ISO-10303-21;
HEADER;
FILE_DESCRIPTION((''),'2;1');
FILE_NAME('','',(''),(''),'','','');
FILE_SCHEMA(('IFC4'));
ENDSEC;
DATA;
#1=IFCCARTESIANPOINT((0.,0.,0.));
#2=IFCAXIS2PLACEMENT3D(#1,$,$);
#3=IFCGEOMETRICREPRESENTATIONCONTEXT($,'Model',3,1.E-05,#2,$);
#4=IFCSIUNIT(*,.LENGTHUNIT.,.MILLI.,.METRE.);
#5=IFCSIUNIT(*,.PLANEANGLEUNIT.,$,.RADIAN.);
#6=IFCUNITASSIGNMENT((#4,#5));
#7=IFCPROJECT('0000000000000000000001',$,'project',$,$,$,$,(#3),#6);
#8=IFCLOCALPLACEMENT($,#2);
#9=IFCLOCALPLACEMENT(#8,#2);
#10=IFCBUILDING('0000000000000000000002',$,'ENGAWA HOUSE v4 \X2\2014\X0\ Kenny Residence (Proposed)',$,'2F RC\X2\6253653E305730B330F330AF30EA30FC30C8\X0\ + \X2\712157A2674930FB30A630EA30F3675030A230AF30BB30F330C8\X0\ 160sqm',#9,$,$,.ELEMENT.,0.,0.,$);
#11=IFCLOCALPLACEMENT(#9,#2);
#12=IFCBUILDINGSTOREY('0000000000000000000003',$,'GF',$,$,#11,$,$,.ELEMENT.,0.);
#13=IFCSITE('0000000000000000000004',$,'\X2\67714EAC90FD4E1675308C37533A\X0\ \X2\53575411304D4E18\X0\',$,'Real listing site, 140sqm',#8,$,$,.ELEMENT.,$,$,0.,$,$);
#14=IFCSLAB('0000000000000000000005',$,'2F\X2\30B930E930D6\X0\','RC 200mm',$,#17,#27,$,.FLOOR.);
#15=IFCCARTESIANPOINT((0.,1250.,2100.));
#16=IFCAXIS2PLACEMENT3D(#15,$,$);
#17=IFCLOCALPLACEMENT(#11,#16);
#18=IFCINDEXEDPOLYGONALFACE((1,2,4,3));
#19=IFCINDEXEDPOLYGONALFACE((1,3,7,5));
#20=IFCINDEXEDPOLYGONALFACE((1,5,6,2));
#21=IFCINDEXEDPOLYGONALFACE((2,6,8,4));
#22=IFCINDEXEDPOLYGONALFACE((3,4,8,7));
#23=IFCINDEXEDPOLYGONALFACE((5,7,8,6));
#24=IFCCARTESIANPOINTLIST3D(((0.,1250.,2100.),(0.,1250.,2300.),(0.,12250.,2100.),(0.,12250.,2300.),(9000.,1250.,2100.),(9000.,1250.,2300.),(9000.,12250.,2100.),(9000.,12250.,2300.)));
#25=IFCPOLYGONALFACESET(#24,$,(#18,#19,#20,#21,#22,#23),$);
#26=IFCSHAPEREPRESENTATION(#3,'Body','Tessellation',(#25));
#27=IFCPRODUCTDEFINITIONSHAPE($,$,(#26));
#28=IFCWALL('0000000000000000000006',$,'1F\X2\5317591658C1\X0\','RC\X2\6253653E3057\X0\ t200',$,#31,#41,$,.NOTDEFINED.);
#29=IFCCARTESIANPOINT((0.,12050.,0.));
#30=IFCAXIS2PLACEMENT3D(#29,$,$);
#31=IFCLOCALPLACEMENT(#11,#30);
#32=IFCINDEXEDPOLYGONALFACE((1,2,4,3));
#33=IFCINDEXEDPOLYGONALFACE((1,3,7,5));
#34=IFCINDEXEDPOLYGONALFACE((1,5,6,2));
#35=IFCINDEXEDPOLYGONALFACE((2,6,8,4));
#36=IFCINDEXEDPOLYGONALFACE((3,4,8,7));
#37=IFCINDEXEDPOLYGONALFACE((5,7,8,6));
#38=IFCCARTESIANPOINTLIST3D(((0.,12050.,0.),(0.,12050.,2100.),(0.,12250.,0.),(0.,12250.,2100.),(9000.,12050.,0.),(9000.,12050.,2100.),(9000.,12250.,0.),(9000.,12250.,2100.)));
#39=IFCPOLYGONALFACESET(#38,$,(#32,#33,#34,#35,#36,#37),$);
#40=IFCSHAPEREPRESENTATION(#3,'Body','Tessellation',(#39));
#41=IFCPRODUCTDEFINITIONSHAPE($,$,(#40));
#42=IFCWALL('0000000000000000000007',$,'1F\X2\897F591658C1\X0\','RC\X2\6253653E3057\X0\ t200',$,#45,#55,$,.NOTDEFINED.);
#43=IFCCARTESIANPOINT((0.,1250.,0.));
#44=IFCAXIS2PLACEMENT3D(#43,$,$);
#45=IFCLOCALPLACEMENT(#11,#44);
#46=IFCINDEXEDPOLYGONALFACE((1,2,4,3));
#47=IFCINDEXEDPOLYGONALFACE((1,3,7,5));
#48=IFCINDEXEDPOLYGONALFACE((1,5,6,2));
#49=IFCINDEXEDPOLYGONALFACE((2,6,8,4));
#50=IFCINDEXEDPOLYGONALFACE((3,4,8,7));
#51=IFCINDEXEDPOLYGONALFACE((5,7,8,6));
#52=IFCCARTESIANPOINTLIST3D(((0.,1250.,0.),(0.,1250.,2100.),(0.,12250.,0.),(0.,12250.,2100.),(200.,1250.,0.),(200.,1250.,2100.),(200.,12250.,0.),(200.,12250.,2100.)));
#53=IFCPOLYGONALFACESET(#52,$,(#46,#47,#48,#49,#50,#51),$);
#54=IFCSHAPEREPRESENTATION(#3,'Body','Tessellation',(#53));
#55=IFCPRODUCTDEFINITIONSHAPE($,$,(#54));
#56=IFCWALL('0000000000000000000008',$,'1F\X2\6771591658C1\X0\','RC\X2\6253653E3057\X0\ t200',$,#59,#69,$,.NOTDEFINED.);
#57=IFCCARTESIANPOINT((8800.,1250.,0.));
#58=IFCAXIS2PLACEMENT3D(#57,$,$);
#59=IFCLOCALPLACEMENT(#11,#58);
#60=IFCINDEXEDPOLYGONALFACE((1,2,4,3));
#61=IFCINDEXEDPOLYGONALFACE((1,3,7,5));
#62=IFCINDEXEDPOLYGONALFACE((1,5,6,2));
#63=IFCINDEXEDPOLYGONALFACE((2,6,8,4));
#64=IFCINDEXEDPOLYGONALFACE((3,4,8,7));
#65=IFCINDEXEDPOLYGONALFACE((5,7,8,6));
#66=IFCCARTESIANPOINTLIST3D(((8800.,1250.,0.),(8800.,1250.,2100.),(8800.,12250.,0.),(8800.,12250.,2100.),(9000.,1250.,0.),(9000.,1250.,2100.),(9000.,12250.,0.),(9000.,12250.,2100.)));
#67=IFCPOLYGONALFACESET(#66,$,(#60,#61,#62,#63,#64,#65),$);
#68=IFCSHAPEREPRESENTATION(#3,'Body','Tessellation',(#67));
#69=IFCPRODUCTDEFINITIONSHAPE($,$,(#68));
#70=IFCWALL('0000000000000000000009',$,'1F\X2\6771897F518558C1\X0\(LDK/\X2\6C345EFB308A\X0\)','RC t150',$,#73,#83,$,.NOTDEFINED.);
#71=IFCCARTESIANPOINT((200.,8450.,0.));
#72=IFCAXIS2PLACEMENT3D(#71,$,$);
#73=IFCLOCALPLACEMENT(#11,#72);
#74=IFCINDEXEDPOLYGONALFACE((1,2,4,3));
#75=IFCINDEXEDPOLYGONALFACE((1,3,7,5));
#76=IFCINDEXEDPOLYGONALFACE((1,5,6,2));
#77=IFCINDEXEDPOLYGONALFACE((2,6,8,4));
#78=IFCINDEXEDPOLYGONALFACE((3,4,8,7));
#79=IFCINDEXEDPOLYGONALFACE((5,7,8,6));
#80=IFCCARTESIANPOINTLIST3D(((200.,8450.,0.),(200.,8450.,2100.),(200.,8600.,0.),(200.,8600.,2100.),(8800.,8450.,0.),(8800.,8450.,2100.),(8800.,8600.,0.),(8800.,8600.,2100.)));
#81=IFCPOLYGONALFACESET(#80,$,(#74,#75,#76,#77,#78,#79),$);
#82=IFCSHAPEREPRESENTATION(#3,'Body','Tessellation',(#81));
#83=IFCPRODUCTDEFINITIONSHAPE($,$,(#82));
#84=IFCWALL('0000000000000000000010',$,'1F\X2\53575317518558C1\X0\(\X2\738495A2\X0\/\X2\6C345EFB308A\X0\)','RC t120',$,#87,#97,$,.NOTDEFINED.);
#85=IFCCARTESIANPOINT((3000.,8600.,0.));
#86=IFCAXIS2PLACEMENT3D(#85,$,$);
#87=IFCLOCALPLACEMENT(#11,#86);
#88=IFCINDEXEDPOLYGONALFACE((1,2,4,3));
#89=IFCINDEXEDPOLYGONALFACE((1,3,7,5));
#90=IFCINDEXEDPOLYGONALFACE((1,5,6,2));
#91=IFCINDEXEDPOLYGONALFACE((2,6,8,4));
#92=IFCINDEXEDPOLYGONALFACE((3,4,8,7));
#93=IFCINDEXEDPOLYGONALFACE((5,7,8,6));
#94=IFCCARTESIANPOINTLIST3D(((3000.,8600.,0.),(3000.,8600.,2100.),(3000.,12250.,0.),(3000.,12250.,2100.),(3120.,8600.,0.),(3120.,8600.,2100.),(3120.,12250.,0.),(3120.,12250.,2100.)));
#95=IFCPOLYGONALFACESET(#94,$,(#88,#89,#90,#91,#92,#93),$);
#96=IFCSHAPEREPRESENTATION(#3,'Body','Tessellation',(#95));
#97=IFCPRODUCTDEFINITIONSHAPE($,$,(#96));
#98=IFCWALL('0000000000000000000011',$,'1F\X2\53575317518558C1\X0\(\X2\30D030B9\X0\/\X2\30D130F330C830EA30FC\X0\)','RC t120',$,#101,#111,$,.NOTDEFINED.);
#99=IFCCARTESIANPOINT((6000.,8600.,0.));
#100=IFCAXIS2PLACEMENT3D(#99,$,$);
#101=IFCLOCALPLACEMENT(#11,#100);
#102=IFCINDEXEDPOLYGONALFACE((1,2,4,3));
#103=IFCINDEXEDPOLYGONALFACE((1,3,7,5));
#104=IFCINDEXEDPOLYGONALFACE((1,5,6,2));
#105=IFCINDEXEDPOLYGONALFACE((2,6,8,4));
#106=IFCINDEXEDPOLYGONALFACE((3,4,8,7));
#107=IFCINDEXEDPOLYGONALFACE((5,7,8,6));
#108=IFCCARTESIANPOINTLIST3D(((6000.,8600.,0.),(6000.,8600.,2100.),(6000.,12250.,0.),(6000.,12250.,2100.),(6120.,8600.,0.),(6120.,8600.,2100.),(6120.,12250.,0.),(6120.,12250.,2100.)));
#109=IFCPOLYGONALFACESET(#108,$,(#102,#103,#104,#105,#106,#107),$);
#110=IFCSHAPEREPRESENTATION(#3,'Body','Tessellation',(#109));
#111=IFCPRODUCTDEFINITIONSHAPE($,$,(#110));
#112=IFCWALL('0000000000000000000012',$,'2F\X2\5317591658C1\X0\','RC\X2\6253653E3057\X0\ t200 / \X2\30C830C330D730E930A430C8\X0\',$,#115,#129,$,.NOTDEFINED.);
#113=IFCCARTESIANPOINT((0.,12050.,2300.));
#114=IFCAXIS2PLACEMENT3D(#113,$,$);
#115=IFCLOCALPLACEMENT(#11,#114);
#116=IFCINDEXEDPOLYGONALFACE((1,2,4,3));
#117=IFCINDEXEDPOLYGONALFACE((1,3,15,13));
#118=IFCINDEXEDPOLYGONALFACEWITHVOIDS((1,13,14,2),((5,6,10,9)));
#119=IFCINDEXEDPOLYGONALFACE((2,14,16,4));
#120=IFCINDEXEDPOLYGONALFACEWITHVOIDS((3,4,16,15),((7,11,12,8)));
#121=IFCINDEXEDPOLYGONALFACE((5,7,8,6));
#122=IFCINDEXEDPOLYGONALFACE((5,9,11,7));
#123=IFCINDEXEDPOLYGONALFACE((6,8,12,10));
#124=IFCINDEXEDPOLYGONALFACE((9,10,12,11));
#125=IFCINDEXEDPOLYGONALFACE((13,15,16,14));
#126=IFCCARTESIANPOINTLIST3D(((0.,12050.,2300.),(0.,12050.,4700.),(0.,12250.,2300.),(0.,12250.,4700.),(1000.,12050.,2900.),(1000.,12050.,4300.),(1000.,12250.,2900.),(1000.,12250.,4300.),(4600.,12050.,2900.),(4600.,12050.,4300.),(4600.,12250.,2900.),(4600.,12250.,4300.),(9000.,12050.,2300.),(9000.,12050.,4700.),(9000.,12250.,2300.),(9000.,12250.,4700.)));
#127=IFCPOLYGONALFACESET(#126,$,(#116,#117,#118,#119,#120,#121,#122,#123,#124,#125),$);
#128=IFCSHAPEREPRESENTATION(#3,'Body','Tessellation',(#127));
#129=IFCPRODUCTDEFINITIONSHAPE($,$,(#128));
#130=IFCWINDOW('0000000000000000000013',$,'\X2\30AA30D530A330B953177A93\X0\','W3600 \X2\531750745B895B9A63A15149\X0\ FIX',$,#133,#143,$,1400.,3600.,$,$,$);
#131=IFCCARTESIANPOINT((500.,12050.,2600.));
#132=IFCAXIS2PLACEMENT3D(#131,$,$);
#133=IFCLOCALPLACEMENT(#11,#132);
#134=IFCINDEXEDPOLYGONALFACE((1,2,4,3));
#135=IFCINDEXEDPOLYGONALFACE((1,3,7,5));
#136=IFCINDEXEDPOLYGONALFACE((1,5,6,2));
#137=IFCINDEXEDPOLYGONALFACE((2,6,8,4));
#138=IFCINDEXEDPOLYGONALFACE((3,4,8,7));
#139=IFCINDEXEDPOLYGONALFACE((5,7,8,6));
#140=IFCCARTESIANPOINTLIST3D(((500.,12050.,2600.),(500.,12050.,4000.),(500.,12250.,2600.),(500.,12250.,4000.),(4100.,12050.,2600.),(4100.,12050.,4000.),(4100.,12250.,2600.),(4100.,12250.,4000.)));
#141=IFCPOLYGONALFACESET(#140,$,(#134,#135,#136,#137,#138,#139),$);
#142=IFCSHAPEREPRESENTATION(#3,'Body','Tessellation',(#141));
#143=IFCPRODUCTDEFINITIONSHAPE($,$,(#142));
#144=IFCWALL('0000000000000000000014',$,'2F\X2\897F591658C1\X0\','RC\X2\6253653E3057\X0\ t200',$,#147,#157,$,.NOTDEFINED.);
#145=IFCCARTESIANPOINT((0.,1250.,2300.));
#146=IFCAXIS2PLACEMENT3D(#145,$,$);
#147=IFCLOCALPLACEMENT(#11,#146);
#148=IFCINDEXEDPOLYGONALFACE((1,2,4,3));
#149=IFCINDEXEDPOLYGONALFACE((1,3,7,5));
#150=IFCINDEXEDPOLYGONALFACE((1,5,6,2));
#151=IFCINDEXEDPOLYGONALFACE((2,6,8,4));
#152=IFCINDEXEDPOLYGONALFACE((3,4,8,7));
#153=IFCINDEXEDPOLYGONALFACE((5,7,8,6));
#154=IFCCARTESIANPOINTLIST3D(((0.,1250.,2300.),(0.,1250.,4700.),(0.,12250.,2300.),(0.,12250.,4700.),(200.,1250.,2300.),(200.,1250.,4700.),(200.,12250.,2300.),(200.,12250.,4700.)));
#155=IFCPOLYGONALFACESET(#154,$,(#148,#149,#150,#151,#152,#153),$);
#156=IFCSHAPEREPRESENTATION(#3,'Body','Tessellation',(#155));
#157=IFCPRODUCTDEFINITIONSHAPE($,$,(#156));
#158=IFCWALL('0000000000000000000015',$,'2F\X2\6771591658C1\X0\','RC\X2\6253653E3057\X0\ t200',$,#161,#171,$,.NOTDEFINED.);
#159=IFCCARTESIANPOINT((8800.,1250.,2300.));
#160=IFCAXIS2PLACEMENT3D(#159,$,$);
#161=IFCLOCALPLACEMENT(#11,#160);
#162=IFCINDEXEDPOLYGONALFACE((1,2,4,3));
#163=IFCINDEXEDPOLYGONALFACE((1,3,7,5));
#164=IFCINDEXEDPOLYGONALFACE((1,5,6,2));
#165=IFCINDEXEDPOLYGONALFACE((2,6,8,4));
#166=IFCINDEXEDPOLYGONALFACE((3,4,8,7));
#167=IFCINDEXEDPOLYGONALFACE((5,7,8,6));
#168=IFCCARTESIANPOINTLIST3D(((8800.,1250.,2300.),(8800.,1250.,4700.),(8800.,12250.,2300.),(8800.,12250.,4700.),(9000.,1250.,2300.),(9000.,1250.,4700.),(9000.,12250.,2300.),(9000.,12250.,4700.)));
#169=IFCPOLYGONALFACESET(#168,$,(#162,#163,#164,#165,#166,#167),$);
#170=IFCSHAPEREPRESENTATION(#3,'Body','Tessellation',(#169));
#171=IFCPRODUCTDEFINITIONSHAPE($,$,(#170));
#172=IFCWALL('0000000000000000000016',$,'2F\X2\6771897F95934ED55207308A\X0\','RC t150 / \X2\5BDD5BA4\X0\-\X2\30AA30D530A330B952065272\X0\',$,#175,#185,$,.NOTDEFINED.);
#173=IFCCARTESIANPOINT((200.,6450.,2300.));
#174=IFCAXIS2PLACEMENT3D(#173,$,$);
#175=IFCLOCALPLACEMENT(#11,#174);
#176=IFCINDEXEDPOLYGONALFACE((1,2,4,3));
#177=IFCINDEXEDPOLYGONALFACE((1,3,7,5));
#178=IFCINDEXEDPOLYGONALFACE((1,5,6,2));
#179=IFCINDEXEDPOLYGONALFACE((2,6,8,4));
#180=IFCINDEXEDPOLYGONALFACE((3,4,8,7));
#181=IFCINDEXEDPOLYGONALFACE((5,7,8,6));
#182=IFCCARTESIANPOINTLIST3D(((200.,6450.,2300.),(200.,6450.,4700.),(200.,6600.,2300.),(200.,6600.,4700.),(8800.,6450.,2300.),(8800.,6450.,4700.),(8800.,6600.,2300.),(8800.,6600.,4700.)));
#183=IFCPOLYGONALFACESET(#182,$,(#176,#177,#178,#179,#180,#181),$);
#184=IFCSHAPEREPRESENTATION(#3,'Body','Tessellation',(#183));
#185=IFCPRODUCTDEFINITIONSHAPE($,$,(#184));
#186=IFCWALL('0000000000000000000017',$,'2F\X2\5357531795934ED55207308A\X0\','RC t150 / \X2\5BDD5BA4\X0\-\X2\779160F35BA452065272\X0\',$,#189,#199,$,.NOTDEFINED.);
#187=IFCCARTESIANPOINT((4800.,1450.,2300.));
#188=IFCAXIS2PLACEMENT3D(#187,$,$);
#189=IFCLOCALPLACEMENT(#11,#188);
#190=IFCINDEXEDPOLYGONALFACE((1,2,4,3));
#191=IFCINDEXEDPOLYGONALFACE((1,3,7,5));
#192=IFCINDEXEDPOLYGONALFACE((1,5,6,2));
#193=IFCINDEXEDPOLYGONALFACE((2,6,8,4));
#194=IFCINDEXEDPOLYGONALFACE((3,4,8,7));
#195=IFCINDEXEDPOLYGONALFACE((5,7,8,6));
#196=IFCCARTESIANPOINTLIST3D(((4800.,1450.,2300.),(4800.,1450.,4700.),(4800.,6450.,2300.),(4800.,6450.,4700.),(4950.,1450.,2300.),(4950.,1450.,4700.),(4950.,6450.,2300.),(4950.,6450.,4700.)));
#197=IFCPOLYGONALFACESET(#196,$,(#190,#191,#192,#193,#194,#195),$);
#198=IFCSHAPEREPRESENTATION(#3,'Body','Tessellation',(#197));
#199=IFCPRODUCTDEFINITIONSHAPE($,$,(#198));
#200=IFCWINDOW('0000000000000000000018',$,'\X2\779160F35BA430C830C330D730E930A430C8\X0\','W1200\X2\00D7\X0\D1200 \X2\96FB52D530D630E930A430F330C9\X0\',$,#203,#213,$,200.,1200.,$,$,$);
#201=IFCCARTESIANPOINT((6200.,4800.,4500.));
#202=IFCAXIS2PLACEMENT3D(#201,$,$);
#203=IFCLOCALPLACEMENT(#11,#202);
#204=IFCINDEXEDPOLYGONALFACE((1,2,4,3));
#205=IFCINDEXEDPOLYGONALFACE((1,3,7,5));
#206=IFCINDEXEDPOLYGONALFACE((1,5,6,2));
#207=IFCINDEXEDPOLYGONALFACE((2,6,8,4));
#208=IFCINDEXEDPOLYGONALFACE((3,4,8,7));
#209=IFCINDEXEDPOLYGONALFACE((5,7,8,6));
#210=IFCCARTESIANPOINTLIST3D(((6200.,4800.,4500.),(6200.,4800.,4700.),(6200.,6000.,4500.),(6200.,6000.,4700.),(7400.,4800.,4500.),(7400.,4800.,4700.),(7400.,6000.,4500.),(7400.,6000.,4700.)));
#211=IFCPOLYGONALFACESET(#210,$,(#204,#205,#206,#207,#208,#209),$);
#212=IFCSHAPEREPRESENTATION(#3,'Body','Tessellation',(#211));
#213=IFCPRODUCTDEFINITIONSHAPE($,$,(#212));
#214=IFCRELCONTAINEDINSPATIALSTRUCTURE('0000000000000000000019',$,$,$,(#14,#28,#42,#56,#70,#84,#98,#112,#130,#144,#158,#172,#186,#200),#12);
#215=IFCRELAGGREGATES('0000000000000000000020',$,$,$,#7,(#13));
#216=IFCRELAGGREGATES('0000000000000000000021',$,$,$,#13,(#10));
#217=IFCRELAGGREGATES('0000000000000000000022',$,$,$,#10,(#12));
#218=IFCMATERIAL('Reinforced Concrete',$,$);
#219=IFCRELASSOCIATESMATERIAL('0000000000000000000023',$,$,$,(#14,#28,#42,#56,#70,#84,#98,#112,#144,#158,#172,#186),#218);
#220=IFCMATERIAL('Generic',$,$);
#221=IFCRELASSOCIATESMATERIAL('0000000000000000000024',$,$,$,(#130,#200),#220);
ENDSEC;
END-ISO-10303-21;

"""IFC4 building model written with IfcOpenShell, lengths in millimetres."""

from ifc_helpers import new_model, si_unit, frame, frame_2d, origin, place, context, project, spatial, rectangle, extrude, material, element, fill, save


model = new_model("IFC4")

# Units and contexts
model_context = context("Model", 3, precision=1e-05, world=origin())
ifc_project = project(units=[si_unit("LENGTHUNIT", "METRE", prefix="MILLI"), si_unit("PLANEANGLEUNIT", "RADIAN")], contexts=[model_context])

# Site, building, storey
site_placement = place(None, origin())
site = spatial("IfcSite", under=ifc_project, at=site_placement, Name="東京都世田谷区 南向き丘", ObjectType="Real listing site, 140sqm", CompositionType="ELEMENT", RefElevation=0.0)
building_placement = place(site_placement, origin())
building = spatial("IfcBuilding", under=site, at=building_placement, Name="ENGAWA HOUSE v4 — Kenny Residence (Proposed)", ObjectType="2F RC打放しコンクリート + 無垢杉・ウリン材アクセント 160sqm", CompositionType="ELEMENT", ElevationOfRefHeight=0.0, ElevationOfTerrain=0.0)
storey_placement = place(building_placement, origin())
storey = spatial("IfcBuildingStorey", under=building, at=storey_placement, Name="GF", CompositionType="ELEMENT", Elevation=0.0)

# Slab
ifc_material_1 = material(Name="Reinforced Concrete")
ifc_material_2 = material(Name="Generic")
slab_1_placement = place(storey_placement, frame((0.0, 1250.0, 2100.0)))
element("IfcSlab", 1, at=slab_1_placement, inside=storey, material=ifc_material_1, Name="2Fスラブ", Description="RC 200mm", PredefinedType="FLOOR", context=model_context, shape_type="SweptSolid", body=[
    extrude(rectangle(XDim=9000.0, YDim=11000.0, at=frame_2d((4500.0, 5500.0))), frame((0.0, 1250.0, 2100.0)), (0.0, 0.0, 1.0), 200.0),
])

# Walls
wall_1_placement = place(storey_placement, frame((0.0, 12050.0, 0.0)))
element("IfcWall", 2, at=wall_1_placement, inside=storey, material=ifc_material_1, Name="1F北外壁", Description="RC打放し t200", PredefinedType="NOTDEFINED", context=model_context, shape_type="SweptSolid", body=[
    extrude(rectangle(XDim=9000.0, YDim=200.0, at=frame_2d((4500.0, 100.0))), frame((0.0, 12050.0, 0.0)), (0.0, 0.0, 1.0), 2100.0),
])
wall_2_placement = place(storey_placement, frame((0.0, 1250.0, 0.0)))
element("IfcWall", 3, at=wall_2_placement, inside=storey, material=ifc_material_1, Name="1F西外壁", Description="RC打放し t200", PredefinedType="NOTDEFINED", context=model_context, shape_type="SweptSolid", body=[
    extrude(rectangle(XDim=200.0, YDim=11000.0, at=frame_2d((100.0, 5500.0))), frame((0.0, 1250.0, 0.0)), (0.0, 0.0, 1.0), 2100.0),
])
wall_3_placement = place(storey_placement, frame((8800.0, 1250.0, 0.0)))
element("IfcWall", 4, at=wall_3_placement, inside=storey, material=ifc_material_1, Name="1F東外壁", Description="RC打放し t200", PredefinedType="NOTDEFINED", context=model_context, shape_type="SweptSolid", body=[
    extrude(rectangle(XDim=200.0, YDim=11000.0, at=frame_2d((100.0, 5500.0))), frame((8800.0, 1250.0, 0.0)), (0.0, 0.0, 1.0), 2100.0),
])
wall_4_placement = place(storey_placement, frame((200.0, 8450.0, 0.0)))
element("IfcWall", 5, at=wall_4_placement, inside=storey, material=ifc_material_1, Name="1F東西内壁(LDK/水廻り)", Description="RC t150", PredefinedType="NOTDEFINED", context=model_context, shape_type="SweptSolid", body=[
    extrude(rectangle(XDim=8600.0, YDim=150.0, at=frame_2d((4300.0, 75.0))), frame((200.0, 8450.0, 0.0)), (0.0, 0.0, 1.0), 2100.0),
])
wall_5_placement = place(storey_placement, frame((3000.0, 8600.0, 0.0)))
element("IfcWall", 6, at=wall_5_placement, inside=storey, material=ifc_material_1, Name="1F南北内壁(玄関/水廻り)", Description="RC t120", PredefinedType="NOTDEFINED", context=model_context, shape_type="SweptSolid", body=[
    extrude(rectangle(XDim=120.0, YDim=3650.0, at=frame_2d((60.0, 1825.0))), frame((3000.0, 8600.0, 0.0)), (0.0, 0.0, 1.0), 2100.0),
])
wall_6_placement = place(storey_placement, frame((6000.0, 8600.0, 0.0)))
element("IfcWall", 7, at=wall_6_placement, inside=storey, material=ifc_material_1, Name="1F南北内壁(バス/パントリー)", Description="RC t120", PredefinedType="NOTDEFINED", context=model_context, shape_type="SweptSolid", body=[
    extrude(rectangle(XDim=120.0, YDim=3650.0, at=frame_2d((60.0, 1825.0))), frame((6000.0, 8600.0, 0.0)), (0.0, 0.0, 1.0), 2100.0),
])

# Wall, opening, window
wall_7_placement = place(storey_placement, frame((0.0, 12050.0, 2300.0)))
wall_7 = element("IfcWall", 8, at=wall_7_placement, inside=storey, material=ifc_material_1, Name="2F北外壁", Description="RC打放し t200 / トップライト", PredefinedType="NOTDEFINED", context=model_context, shape_type="SweptSolid", body=[
    extrude(rectangle(XDim=9000.0, YDim=200.0, at=frame_2d((4500.0, 100.0))), frame((0.0, 12050.0, 2300.0)), (0.0, 0.0, 1.0), 2400.0),
])
opening_1_placement = place(storey_placement, frame((500.0, 12050.0, 2600.0)))
opening_1 = element("IfcOpeningElement", 9, at=opening_1_placement, cuts=wall_7, PredefinedType="NOTDEFINED", context=model_context, shape_type="SweptSolid", body=[
    extrude(rectangle(XDim=3600.0, YDim=200.0, at=frame_2d((1800.0, 100.0))), frame((500.0, 12050.0, 2600.0)), (0.0, 0.0, 1.0), 1400.0),
])
window_1_placement = place(storey_placement, frame((500.0, 12050.0, 2600.0)))
window_1 = element("IfcWindow", 10, at=window_1_placement, inside=storey, material=ifc_material_2, Name="オフィス北窓", Description="W3600 北側安定採光 FIX", OverallHeight=1400.0, OverallWidth=3600.0, context=model_context, shape_type="SweptSolid", body=[
    extrude(rectangle(XDim=3600.0, YDim=200.0, at=frame_2d((1800.0, 100.0))), frame((500.0, 12050.0, 2600.0)), (0.0, 0.0, 1.0), 1400.0),
])
fill(opening_1, window_1)

# Walls
wall_8_placement = place(storey_placement, frame((0.0, 1250.0, 2300.0)))
element("IfcWall", 11, at=wall_8_placement, inside=storey, material=ifc_material_1, Name="2F西外壁", Description="RC打放し t200", PredefinedType="NOTDEFINED", context=model_context, shape_type="SweptSolid", body=[
    extrude(rectangle(XDim=200.0, YDim=11000.0, at=frame_2d((100.0, 5500.0))), frame((0.0, 1250.0, 2300.0)), (0.0, 0.0, 1.0), 2400.0),
])
wall_9_placement = place(storey_placement, frame((8800.0, 1250.0, 2300.0)))
element("IfcWall", 12, at=wall_9_placement, inside=storey, material=ifc_material_1, Name="2F東外壁", Description="RC打放し t200", PredefinedType="NOTDEFINED", context=model_context, shape_type="SweptSolid", body=[
    extrude(rectangle(XDim=200.0, YDim=11000.0, at=frame_2d((100.0, 5500.0))), frame((8800.0, 1250.0, 2300.0)), (0.0, 0.0, 1.0), 2400.0),
])
wall_10_placement = place(storey_placement, frame((200.0, 6450.0, 2300.0)))
element("IfcWall", 13, at=wall_10_placement, inside=storey, material=ifc_material_1, Name="2F東西間仕切り", Description="RC t150 / 寝室-オフィス分割", PredefinedType="NOTDEFINED", context=model_context, shape_type="SweptSolid", body=[
    extrude(rectangle(XDim=8600.0, YDim=150.0, at=frame_2d((4300.0, 75.0))), frame((200.0, 6450.0, 2300.0)), (0.0, 0.0, 1.0), 2400.0),
])
wall_11_placement = place(storey_placement, frame((4800.0, 1450.0, 2300.0)))
element("IfcWall", 14, at=wall_11_placement, inside=storey, material=ifc_material_1, Name="2F南北間仕切り", Description="RC t150 / 寝室-瞑想室分割", PredefinedType="NOTDEFINED", context=model_context, shape_type="SweptSolid", body=[
    extrude(rectangle(XDim=150.0, YDim=5000.0, at=frame_2d((75.0, 2500.0))), frame((4800.0, 1450.0, 2300.0)), (0.0, 0.0, 1.0), 2400.0),
])

# Window
window_2_placement = place(storey_placement, frame((6200.0, 4800.0, 4500.0)))
element("IfcWindow", 15, at=window_2_placement, inside=storey, material=ifc_material_2, Name="瞑想室トップライト", Description="W1200×D1200 電動ブラインド", OverallHeight=200.0, OverallWidth=1200.0, context=model_context, shape_type="SweptSolid", body=[
    extrude(rectangle(XDim=1200.0, YDim=1200.0, at=frame_2d((600.0, 600.0))), frame((6200.0, 4800.0, 4500.0)), (0.0, 0.0, 1.0), 200.0),
])

save(model, "model.ifc")
